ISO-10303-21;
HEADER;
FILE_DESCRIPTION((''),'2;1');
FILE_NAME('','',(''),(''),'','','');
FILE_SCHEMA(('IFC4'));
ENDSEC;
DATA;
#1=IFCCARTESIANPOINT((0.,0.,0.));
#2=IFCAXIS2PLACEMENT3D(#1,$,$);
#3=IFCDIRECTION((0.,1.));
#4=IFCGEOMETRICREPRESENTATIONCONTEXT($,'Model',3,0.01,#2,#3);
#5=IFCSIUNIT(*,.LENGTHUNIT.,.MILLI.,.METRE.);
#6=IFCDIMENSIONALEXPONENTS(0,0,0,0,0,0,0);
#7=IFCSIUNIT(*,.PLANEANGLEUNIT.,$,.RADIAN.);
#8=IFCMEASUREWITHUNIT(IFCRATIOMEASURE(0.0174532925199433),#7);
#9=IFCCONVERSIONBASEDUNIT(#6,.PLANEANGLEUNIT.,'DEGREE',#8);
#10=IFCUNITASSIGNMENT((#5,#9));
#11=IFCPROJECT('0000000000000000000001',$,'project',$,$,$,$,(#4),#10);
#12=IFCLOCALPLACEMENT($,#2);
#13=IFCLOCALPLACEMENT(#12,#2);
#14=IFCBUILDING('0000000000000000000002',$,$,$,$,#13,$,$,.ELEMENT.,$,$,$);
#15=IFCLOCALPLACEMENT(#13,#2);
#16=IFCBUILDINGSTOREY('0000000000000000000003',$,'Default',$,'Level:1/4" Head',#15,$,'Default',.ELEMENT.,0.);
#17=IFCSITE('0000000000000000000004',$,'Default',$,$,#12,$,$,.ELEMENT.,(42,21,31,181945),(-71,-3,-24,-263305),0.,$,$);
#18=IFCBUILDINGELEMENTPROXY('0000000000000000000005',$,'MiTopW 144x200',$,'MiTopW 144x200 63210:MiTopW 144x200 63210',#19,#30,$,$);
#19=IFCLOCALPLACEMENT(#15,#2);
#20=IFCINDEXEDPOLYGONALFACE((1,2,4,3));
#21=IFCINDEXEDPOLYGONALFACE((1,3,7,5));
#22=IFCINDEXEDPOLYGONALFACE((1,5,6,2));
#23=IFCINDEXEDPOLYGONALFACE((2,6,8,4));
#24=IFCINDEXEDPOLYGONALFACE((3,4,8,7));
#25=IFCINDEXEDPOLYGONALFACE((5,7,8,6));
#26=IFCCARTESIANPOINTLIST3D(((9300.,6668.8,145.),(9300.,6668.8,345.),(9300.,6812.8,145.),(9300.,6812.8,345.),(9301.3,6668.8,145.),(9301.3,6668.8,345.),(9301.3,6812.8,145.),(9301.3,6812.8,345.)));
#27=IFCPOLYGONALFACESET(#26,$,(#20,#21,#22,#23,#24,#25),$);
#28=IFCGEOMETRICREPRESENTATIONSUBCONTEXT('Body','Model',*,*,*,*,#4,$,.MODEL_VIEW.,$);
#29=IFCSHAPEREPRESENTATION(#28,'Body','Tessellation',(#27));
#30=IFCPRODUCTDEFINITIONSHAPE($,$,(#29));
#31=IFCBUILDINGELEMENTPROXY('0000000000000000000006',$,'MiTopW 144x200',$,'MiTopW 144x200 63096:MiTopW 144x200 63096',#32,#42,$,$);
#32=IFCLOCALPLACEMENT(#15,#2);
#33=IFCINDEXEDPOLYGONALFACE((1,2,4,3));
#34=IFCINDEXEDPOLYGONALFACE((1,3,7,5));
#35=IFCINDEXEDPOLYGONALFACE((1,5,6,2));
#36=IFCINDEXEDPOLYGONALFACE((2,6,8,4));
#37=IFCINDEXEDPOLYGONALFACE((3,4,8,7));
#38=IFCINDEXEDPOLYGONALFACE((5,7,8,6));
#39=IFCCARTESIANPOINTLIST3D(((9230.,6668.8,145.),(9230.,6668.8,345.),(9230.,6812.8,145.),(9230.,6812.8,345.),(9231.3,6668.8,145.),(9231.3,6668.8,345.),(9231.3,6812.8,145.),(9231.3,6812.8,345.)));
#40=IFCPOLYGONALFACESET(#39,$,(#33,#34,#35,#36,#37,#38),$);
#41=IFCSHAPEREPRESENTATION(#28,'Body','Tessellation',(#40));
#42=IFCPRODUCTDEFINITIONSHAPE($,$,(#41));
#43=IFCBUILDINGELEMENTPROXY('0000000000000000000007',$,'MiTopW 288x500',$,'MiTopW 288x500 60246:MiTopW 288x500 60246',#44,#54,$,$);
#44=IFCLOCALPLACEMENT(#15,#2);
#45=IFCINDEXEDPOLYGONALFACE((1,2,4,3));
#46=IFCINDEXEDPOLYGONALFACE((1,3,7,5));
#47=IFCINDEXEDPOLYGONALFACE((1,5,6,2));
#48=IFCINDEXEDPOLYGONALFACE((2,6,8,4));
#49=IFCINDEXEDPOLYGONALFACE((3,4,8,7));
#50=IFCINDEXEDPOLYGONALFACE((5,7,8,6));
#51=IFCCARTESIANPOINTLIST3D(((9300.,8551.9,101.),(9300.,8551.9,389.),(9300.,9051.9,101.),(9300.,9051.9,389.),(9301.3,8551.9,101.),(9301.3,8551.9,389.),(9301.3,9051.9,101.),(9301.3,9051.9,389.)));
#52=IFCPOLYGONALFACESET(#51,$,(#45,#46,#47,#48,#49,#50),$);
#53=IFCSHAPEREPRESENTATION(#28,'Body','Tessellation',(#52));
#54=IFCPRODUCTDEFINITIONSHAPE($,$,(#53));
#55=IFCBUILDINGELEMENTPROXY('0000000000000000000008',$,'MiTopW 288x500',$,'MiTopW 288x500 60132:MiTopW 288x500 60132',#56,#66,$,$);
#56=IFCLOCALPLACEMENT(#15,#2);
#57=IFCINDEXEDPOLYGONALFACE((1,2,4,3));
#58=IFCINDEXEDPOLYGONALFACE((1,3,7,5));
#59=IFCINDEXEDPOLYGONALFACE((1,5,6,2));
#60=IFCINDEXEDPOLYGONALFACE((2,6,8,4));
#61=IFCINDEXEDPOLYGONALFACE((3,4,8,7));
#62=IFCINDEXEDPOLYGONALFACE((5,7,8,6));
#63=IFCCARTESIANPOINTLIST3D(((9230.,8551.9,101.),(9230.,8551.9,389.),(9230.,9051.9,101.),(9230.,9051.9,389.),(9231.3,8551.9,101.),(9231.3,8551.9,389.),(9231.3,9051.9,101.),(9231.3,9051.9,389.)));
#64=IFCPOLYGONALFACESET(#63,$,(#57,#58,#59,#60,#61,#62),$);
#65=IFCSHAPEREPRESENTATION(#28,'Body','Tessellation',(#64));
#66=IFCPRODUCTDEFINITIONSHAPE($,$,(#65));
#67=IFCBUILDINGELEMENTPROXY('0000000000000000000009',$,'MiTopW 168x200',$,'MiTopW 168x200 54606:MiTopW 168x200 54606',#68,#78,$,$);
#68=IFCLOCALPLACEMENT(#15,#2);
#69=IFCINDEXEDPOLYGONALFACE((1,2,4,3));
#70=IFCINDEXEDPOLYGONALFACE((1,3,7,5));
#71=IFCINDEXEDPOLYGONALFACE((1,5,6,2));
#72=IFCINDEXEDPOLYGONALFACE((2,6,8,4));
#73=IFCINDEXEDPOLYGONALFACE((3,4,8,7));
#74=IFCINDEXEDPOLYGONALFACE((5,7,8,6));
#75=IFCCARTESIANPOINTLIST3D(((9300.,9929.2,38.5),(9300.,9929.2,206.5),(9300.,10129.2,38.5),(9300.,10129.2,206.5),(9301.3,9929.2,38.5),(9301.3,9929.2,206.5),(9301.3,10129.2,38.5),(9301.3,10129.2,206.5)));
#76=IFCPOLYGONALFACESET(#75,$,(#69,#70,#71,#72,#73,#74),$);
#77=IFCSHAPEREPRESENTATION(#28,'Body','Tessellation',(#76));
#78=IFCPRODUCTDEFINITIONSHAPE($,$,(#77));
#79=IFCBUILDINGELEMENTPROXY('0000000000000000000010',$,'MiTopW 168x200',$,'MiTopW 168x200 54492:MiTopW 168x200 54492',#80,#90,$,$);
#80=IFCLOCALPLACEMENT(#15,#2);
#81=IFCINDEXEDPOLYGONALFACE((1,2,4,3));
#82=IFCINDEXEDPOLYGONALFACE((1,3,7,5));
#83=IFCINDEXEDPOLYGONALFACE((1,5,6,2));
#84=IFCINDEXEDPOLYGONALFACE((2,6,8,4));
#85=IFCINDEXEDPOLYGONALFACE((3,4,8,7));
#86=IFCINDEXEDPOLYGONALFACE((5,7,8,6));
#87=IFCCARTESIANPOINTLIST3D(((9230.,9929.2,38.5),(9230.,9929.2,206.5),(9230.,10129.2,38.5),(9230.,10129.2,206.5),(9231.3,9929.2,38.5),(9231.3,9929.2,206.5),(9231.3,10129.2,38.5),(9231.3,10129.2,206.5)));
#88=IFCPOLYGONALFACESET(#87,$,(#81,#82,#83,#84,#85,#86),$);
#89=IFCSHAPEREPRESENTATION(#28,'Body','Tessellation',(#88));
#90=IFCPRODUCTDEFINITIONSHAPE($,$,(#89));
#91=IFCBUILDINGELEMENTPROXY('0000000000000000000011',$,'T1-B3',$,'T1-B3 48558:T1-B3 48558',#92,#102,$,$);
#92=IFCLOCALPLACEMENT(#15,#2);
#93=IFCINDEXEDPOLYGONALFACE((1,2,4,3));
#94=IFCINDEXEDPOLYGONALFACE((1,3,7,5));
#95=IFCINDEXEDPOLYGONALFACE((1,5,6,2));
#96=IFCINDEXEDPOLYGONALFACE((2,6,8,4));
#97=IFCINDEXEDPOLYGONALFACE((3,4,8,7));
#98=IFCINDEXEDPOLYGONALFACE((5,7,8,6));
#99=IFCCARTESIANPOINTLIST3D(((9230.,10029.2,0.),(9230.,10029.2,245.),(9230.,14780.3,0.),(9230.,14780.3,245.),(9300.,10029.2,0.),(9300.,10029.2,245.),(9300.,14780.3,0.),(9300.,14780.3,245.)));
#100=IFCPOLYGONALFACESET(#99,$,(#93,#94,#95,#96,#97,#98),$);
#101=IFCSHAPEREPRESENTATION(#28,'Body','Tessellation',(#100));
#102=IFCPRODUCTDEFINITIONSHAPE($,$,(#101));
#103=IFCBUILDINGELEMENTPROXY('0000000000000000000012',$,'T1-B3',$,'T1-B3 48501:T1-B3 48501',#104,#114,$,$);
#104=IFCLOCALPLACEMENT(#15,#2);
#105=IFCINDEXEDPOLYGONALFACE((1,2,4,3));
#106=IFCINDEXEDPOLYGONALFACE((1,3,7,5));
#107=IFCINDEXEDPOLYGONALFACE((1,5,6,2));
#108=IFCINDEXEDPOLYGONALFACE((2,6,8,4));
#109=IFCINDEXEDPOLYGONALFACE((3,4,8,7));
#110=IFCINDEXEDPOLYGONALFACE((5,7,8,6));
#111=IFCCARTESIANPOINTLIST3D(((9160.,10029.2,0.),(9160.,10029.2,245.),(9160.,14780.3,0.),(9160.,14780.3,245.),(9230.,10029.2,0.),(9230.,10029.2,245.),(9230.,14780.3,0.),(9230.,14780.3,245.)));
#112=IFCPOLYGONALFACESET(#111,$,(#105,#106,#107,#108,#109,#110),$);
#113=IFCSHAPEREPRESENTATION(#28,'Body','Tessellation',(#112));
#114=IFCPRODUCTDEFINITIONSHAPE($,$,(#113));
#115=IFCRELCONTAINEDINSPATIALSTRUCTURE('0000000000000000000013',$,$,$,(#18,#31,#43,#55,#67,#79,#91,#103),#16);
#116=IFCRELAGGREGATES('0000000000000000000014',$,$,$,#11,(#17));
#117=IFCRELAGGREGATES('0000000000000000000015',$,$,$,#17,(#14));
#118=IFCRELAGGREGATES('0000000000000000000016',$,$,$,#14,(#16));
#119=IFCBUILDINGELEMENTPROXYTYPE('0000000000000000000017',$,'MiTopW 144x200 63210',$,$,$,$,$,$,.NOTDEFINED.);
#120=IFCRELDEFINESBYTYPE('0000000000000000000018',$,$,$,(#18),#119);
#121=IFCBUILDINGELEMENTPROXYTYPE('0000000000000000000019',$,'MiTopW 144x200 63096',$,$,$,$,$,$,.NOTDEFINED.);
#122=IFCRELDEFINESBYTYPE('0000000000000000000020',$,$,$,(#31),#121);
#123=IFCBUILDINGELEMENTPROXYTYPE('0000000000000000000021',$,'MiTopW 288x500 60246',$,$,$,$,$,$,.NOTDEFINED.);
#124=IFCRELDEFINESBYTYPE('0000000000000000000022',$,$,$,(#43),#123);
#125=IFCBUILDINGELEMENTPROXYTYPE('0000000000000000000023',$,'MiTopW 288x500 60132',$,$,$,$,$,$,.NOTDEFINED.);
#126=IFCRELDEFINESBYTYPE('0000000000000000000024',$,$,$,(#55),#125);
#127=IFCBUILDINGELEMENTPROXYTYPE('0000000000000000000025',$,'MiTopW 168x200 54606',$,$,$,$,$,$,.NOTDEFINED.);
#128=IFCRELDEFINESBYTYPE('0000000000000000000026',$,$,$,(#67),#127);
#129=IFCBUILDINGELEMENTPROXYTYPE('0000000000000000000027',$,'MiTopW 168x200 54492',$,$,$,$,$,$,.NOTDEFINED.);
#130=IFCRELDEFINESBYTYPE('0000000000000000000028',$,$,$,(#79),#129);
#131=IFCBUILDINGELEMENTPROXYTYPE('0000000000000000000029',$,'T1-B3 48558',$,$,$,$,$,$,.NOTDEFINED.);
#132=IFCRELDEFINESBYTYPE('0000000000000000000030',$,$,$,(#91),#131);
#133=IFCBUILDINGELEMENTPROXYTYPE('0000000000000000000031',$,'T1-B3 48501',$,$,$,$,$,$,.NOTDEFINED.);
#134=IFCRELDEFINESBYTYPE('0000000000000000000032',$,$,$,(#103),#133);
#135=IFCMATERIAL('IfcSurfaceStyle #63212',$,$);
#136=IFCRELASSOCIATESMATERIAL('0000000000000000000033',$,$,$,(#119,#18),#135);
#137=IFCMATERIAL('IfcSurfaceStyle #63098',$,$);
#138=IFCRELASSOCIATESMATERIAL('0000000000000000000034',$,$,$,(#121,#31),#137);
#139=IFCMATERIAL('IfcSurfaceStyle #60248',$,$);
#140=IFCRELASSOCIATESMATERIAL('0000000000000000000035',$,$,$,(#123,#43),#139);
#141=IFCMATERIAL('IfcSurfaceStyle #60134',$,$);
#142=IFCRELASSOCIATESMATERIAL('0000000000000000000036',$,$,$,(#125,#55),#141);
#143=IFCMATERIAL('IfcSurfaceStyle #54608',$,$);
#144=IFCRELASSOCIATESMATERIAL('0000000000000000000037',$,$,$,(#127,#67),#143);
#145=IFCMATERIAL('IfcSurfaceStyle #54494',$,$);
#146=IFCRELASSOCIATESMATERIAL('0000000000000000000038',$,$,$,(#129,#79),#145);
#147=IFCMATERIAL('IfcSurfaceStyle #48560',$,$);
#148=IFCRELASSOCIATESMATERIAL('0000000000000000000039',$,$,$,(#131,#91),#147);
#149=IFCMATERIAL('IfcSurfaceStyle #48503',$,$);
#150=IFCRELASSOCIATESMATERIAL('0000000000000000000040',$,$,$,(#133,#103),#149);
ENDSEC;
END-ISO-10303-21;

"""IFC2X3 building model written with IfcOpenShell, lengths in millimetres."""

from ifc_helpers import new_model, entity, si_unit, converted_unit, direction, frame, frame_2d, origin, origin_2d_with_axis, place, context, subcontext, project, spatial, rectangle, extrude, source, transform, mapped, material, type_object, type_shapes, element, save


model = new_model("IFC2X3")

# Units and contexts
model_context = context("Model", 3, precision=0.01, world=origin(), true_north=direction((0.0, 1.0)))
body_context = subcontext(model_context, "Body", "Model", "MODEL_VIEW")
ifc_project = project(units=[si_unit("LENGTHUNIT", "METRE", prefix="MILLI"), converted_unit("PLANEANGLEUNIT", "DEGREE", entity("IfcRatioMeasure", 0.0174532925199433), si_unit("PLANEANGLEUNIT", "RADIAN"), dimensions=[0, 0, 0, 0, 0, 0, 0])], contexts=[model_context])

# Site, building, storey
site_placement = place(None, origin())
site = spatial("IfcSite", under=ifc_project, at=site_placement, Name="Default", CompositionType="ELEMENT", RefLatitude=(42, 21, 31, 181945), RefLongitude=(-71, -3, -24, -263305), RefElevation=0.0)
building_placement = place(site_placement, origin())
building = spatial("IfcBuilding", under=site, at=building_placement, CompositionType="ELEMENT")
storey_placement = place(building_placement, origin())
storey = spatial("IfcBuildingStorey", under=building, at=storey_placement, Name="Default", ObjectType="Level:1/4\" Head", LongName="Default", CompositionType="ELEMENT", Elevation=0.0)

# Building element proxies
ifc_material_1 = material(Name="IfcSurfaceStyle #63212")
building_element_proxy_type_1 = type_object("IfcBuildingElementProxyType", Name="MiTopW 144x200 63210", PredefinedType="NOTDEFINED", material=ifc_material_1)
shared_shape_1 = source(origin(), body_context, "Body", "SweptSolid", [
    extrude(rectangle(XDim=200.0, YDim=144.0, at=frame_2d((0.0, 0.0), x_axis=(1.0, 0.0))), frame((100.0, 72.0, 0.0), z_axis=(0.0, 0.0, 1.0), x_axis=(-1.0, 0.0, 0.0)), (0.0, 0.0, 1.0), 1.3),
])
type_shapes(building_element_proxy_type_1, [shared_shape_1])
proxy_1_placement = place(building_placement, frame((9301.3, 6668.8, 145.0), z_axis=(-1.0, 0.0, 0.0), x_axis=(0.0, 0.0, 1.0)))
element("IfcBuildingElementProxy", 1, at=proxy_1_placement, inside=storey, type_object=building_element_proxy_type_1, material=ifc_material_1, Name="MiTopW 144x200", ObjectType="MiTopW 144x200 63210:MiTopW 144x200 63210", context=body_context, shape_type="MappedRepresentation", body=[
    mapped(shared_shape_1, transform((0.0, 0.0, 0.0), scale=1.0)),
])
ifc_material_2 = material(Name="IfcSurfaceStyle #63098")
building_element_proxy_type_2 = type_object("IfcBuildingElementProxyType", Name="MiTopW 144x200 63096", PredefinedType="NOTDEFINED", material=ifc_material_2)
shared_shape_2 = source(origin(), body_context, "Body", "SweptSolid", [
    extrude(rectangle(XDim=200.0, YDim=144.0, at=frame_2d((0.0, 0.0), x_axis=(1.0, 0.0))), frame((100.0, 72.0, 0.0), z_axis=(0.0, 0.0, 1.0), x_axis=(-1.0, 0.0, 0.0)), (0.0, 0.0, 1.0), 1.3),
])
type_shapes(building_element_proxy_type_2, [shared_shape_2])
proxy_2_placement = place(building_placement, frame((9231.3, 6668.8, 145.0), z_axis=(-1.0, 0.0, 0.0), x_axis=(0.0, 0.0, 1.0)))
element("IfcBuildingElementProxy", 2, at=proxy_2_placement, inside=storey, type_object=building_element_proxy_type_2, material=ifc_material_2, Name="MiTopW 144x200", ObjectType="MiTopW 144x200 63096:MiTopW 144x200 63096", context=body_context, shape_type="MappedRepresentation", body=[
    mapped(shared_shape_2, transform((0.0, 0.0, 0.0), scale=1.0)),
])
ifc_material_3 = material(Name="IfcSurfaceStyle #60248")
building_element_proxy_type_3 = type_object("IfcBuildingElementProxyType", Name="MiTopW 288x500 60246", PredefinedType="NOTDEFINED", material=ifc_material_3)
shared_shape_3 = source(origin(), body_context, "Body", "SweptSolid", [
    extrude(rectangle(XDim=500.0, YDim=288.0, at=frame_2d((0.0, 0.0), x_axis=(1.0, 0.0))), frame((250.0, 144.0, 0.0), z_axis=(0.0, 0.0, 1.0), x_axis=(-1.0, 0.0, 0.0)), (0.0, 0.0, 1.0), 1.3),
])
type_shapes(building_element_proxy_type_3, [shared_shape_3])
proxy_3_placement = place(building_placement, frame((9301.3, 8551.9, 389.0), z_axis=(-1.0, 0.0, 0.0), x_axis=(0.0, 1.0, 0.0)))
element("IfcBuildingElementProxy", 3, at=proxy_3_placement, inside=storey, type_object=building_element_proxy_type_3, material=ifc_material_3, Name="MiTopW 288x500", ObjectType="MiTopW 288x500 60246:MiTopW 288x500 60246", context=body_context, shape_type="MappedRepresentation", body=[
    mapped(shared_shape_3, transform((0.0, 0.0, 0.0), scale=1.0)),
])
ifc_material_4 = material(Name="IfcSurfaceStyle #60134")
building_element_proxy_type_4 = type_object("IfcBuildingElementProxyType", Name="MiTopW 288x500 60132", PredefinedType="NOTDEFINED", material=ifc_material_4)
shared_shape_4 = source(origin(), body_context, "Body", "SweptSolid", [
    extrude(rectangle(XDim=500.0, YDim=288.0, at=frame_2d((0.0, 0.0), x_axis=(1.0, 0.0))), frame((250.0, 144.0, 0.0), z_axis=(0.0, 0.0, 1.0), x_axis=(-1.0, 0.0, 0.0)), (0.0, 0.0, 1.0), 1.3),
])
type_shapes(building_element_proxy_type_4, [shared_shape_4])
proxy_4_placement = place(building_placement, frame((9231.3, 8551.9, 389.0), z_axis=(-1.0, 0.0, 0.0), x_axis=(0.0, 1.0, 0.0)))
element("IfcBuildingElementProxy", 4, at=proxy_4_placement, inside=storey, type_object=building_element_proxy_type_4, material=ifc_material_4, Name="MiTopW 288x500", ObjectType="MiTopW 288x500 60132:MiTopW 288x500 60132", context=body_context, shape_type="MappedRepresentation", body=[
    mapped(shared_shape_4, transform((0.0, 0.0, 0.0), scale=1.0)),
])
ifc_material_5 = material(Name="IfcSurfaceStyle #54608")
building_element_proxy_type_5 = type_object("IfcBuildingElementProxyType", Name="MiTopW 168x200 54606", PredefinedType="NOTDEFINED", material=ifc_material_5)
shared_shape_5 = source(origin(), body_context, "Body", "SweptSolid", [
    extrude(rectangle(XDim=200.0, YDim=168.0, at=origin_2d_with_axis()), frame((100.0, 84.0, 0.0), z_axis=(0.0, 0.0, 1.0), x_axis=(-1.0, 0.0, 0.0)), (0.0, 0.0, 1.0), 1.3),
])
type_shapes(building_element_proxy_type_5, [shared_shape_5])
proxy_5_placement = place(building_placement, frame((9301.3, 9929.2, 206.5), z_axis=(-1.0, 0.0, 0.0), x_axis=(0.0, 1.0, 0.0)))
element("IfcBuildingElementProxy", 5, at=proxy_5_placement, inside=storey, type_object=building_element_proxy_type_5, material=ifc_material_5, Name="MiTopW 168x200", ObjectType="MiTopW 168x200 54606:MiTopW 168x200 54606", context=body_context, shape_type="MappedRepresentation", body=[
    mapped(shared_shape_5, transform((0.0, 0.0, 0.0), scale=1.0)),
])
ifc_material_6 = material(Name="IfcSurfaceStyle #54494")
building_element_proxy_type_6 = type_object("IfcBuildingElementProxyType", Name="MiTopW 168x200 54492", PredefinedType="NOTDEFINED", material=ifc_material_6)
shared_shape_6 = source(origin(), body_context, "Body", "SweptSolid", [
    extrude(rectangle(XDim=200.0, YDim=168.0, at=origin_2d_with_axis()), frame((100.0, 84.0, 0.0), z_axis=(0.0, 0.0, 1.0), x_axis=(-1.0, 0.0, 0.0)), (0.0, 0.0, 1.0), 1.3),
])
type_shapes(building_element_proxy_type_6, [shared_shape_6])
proxy_6_placement = place(building_placement, frame((9231.3, 9929.2, 206.5), z_axis=(-1.0, 0.0, 0.0), x_axis=(0.0, 1.0, 0.0)))
element("IfcBuildingElementProxy", 6, at=proxy_6_placement, inside=storey, type_object=building_element_proxy_type_6, material=ifc_material_6, Name="MiTopW 168x200", ObjectType="MiTopW 168x200 54492:MiTopW 168x200 54492", context=body_context, shape_type="MappedRepresentation", body=[
    mapped(shared_shape_6, transform((0.0, 0.0, 0.0), scale=1.0)),
])
ifc_material_7 = material(Name="IfcSurfaceStyle #48560")
building_element_proxy_type_7 = type_object("IfcBuildingElementProxyType", Name="T1-B3 48558", PredefinedType="NOTDEFINED", material=ifc_material_7)
shared_shape_7 = source(origin(), body_context, "Body", "SweptSolid", [
    extrude(rectangle(XDim=4751.0, YDim=245.0, at=origin_2d_with_axis()), frame((2375.5, 122.5, 0.0), z_axis=(0.0, 0.0, 1.0), x_axis=(-1.0, 0.0, 0.0)), (0.0, 0.0, 1.0), 70.0),
])
type_shapes(building_element_proxy_type_7, [shared_shape_7])
proxy_7_placement = place(building_placement, frame((9300.0, 10029.2, 245.0), z_axis=(-1.0, 0.0, 0.0), x_axis=(0.0, 1.0, 0.0)))
element("IfcBuildingElementProxy", 7, at=proxy_7_placement, inside=storey, type_object=building_element_proxy_type_7, material=ifc_material_7, Name="T1-B3", ObjectType="T1-B3 48558:T1-B3 48558", context=body_context, shape_type="MappedRepresentation", body=[
    mapped(shared_shape_7, transform((0.0, 0.0, 0.0), scale=1.0)),
])
ifc_material_8 = material(Name="IfcSurfaceStyle #48503")
building_element_proxy_type_8 = type_object("IfcBuildingElementProxyType", Name="T1-B3 48501", PredefinedType="NOTDEFINED", material=ifc_material_8)
shared_shape_8 = source(origin(), body_context, "Body", "SweptSolid", [
    extrude(rectangle(XDim=4751.0, YDim=245.0, at=origin_2d_with_axis()), frame((2375.5, 122.5, 0.0), z_axis=(0.0, 0.0, 1.0), x_axis=(-1.0, 0.0, 0.0)), (0.0, 0.0, 1.0), 70.0),
])
type_shapes(building_element_proxy_type_8, [shared_shape_8])
proxy_8_placement = place(building_placement, frame((9230.0, 10029.2, 245.0), z_axis=(-1.0, 0.0, 0.0), x_axis=(0.0, 1.0, 0.0)))
element("IfcBuildingElementProxy", 8, at=proxy_8_placement, inside=storey, type_object=building_element_proxy_type_8, material=ifc_material_8, Name="T1-B3", ObjectType="T1-B3 48501:T1-B3 48501", context=body_context, shape_type="MappedRepresentation", body=[
    mapped(shared_shape_8, transform((0.0, 0.0, 0.0), scale=1.0)),
])

save(model, "model.ifc")
